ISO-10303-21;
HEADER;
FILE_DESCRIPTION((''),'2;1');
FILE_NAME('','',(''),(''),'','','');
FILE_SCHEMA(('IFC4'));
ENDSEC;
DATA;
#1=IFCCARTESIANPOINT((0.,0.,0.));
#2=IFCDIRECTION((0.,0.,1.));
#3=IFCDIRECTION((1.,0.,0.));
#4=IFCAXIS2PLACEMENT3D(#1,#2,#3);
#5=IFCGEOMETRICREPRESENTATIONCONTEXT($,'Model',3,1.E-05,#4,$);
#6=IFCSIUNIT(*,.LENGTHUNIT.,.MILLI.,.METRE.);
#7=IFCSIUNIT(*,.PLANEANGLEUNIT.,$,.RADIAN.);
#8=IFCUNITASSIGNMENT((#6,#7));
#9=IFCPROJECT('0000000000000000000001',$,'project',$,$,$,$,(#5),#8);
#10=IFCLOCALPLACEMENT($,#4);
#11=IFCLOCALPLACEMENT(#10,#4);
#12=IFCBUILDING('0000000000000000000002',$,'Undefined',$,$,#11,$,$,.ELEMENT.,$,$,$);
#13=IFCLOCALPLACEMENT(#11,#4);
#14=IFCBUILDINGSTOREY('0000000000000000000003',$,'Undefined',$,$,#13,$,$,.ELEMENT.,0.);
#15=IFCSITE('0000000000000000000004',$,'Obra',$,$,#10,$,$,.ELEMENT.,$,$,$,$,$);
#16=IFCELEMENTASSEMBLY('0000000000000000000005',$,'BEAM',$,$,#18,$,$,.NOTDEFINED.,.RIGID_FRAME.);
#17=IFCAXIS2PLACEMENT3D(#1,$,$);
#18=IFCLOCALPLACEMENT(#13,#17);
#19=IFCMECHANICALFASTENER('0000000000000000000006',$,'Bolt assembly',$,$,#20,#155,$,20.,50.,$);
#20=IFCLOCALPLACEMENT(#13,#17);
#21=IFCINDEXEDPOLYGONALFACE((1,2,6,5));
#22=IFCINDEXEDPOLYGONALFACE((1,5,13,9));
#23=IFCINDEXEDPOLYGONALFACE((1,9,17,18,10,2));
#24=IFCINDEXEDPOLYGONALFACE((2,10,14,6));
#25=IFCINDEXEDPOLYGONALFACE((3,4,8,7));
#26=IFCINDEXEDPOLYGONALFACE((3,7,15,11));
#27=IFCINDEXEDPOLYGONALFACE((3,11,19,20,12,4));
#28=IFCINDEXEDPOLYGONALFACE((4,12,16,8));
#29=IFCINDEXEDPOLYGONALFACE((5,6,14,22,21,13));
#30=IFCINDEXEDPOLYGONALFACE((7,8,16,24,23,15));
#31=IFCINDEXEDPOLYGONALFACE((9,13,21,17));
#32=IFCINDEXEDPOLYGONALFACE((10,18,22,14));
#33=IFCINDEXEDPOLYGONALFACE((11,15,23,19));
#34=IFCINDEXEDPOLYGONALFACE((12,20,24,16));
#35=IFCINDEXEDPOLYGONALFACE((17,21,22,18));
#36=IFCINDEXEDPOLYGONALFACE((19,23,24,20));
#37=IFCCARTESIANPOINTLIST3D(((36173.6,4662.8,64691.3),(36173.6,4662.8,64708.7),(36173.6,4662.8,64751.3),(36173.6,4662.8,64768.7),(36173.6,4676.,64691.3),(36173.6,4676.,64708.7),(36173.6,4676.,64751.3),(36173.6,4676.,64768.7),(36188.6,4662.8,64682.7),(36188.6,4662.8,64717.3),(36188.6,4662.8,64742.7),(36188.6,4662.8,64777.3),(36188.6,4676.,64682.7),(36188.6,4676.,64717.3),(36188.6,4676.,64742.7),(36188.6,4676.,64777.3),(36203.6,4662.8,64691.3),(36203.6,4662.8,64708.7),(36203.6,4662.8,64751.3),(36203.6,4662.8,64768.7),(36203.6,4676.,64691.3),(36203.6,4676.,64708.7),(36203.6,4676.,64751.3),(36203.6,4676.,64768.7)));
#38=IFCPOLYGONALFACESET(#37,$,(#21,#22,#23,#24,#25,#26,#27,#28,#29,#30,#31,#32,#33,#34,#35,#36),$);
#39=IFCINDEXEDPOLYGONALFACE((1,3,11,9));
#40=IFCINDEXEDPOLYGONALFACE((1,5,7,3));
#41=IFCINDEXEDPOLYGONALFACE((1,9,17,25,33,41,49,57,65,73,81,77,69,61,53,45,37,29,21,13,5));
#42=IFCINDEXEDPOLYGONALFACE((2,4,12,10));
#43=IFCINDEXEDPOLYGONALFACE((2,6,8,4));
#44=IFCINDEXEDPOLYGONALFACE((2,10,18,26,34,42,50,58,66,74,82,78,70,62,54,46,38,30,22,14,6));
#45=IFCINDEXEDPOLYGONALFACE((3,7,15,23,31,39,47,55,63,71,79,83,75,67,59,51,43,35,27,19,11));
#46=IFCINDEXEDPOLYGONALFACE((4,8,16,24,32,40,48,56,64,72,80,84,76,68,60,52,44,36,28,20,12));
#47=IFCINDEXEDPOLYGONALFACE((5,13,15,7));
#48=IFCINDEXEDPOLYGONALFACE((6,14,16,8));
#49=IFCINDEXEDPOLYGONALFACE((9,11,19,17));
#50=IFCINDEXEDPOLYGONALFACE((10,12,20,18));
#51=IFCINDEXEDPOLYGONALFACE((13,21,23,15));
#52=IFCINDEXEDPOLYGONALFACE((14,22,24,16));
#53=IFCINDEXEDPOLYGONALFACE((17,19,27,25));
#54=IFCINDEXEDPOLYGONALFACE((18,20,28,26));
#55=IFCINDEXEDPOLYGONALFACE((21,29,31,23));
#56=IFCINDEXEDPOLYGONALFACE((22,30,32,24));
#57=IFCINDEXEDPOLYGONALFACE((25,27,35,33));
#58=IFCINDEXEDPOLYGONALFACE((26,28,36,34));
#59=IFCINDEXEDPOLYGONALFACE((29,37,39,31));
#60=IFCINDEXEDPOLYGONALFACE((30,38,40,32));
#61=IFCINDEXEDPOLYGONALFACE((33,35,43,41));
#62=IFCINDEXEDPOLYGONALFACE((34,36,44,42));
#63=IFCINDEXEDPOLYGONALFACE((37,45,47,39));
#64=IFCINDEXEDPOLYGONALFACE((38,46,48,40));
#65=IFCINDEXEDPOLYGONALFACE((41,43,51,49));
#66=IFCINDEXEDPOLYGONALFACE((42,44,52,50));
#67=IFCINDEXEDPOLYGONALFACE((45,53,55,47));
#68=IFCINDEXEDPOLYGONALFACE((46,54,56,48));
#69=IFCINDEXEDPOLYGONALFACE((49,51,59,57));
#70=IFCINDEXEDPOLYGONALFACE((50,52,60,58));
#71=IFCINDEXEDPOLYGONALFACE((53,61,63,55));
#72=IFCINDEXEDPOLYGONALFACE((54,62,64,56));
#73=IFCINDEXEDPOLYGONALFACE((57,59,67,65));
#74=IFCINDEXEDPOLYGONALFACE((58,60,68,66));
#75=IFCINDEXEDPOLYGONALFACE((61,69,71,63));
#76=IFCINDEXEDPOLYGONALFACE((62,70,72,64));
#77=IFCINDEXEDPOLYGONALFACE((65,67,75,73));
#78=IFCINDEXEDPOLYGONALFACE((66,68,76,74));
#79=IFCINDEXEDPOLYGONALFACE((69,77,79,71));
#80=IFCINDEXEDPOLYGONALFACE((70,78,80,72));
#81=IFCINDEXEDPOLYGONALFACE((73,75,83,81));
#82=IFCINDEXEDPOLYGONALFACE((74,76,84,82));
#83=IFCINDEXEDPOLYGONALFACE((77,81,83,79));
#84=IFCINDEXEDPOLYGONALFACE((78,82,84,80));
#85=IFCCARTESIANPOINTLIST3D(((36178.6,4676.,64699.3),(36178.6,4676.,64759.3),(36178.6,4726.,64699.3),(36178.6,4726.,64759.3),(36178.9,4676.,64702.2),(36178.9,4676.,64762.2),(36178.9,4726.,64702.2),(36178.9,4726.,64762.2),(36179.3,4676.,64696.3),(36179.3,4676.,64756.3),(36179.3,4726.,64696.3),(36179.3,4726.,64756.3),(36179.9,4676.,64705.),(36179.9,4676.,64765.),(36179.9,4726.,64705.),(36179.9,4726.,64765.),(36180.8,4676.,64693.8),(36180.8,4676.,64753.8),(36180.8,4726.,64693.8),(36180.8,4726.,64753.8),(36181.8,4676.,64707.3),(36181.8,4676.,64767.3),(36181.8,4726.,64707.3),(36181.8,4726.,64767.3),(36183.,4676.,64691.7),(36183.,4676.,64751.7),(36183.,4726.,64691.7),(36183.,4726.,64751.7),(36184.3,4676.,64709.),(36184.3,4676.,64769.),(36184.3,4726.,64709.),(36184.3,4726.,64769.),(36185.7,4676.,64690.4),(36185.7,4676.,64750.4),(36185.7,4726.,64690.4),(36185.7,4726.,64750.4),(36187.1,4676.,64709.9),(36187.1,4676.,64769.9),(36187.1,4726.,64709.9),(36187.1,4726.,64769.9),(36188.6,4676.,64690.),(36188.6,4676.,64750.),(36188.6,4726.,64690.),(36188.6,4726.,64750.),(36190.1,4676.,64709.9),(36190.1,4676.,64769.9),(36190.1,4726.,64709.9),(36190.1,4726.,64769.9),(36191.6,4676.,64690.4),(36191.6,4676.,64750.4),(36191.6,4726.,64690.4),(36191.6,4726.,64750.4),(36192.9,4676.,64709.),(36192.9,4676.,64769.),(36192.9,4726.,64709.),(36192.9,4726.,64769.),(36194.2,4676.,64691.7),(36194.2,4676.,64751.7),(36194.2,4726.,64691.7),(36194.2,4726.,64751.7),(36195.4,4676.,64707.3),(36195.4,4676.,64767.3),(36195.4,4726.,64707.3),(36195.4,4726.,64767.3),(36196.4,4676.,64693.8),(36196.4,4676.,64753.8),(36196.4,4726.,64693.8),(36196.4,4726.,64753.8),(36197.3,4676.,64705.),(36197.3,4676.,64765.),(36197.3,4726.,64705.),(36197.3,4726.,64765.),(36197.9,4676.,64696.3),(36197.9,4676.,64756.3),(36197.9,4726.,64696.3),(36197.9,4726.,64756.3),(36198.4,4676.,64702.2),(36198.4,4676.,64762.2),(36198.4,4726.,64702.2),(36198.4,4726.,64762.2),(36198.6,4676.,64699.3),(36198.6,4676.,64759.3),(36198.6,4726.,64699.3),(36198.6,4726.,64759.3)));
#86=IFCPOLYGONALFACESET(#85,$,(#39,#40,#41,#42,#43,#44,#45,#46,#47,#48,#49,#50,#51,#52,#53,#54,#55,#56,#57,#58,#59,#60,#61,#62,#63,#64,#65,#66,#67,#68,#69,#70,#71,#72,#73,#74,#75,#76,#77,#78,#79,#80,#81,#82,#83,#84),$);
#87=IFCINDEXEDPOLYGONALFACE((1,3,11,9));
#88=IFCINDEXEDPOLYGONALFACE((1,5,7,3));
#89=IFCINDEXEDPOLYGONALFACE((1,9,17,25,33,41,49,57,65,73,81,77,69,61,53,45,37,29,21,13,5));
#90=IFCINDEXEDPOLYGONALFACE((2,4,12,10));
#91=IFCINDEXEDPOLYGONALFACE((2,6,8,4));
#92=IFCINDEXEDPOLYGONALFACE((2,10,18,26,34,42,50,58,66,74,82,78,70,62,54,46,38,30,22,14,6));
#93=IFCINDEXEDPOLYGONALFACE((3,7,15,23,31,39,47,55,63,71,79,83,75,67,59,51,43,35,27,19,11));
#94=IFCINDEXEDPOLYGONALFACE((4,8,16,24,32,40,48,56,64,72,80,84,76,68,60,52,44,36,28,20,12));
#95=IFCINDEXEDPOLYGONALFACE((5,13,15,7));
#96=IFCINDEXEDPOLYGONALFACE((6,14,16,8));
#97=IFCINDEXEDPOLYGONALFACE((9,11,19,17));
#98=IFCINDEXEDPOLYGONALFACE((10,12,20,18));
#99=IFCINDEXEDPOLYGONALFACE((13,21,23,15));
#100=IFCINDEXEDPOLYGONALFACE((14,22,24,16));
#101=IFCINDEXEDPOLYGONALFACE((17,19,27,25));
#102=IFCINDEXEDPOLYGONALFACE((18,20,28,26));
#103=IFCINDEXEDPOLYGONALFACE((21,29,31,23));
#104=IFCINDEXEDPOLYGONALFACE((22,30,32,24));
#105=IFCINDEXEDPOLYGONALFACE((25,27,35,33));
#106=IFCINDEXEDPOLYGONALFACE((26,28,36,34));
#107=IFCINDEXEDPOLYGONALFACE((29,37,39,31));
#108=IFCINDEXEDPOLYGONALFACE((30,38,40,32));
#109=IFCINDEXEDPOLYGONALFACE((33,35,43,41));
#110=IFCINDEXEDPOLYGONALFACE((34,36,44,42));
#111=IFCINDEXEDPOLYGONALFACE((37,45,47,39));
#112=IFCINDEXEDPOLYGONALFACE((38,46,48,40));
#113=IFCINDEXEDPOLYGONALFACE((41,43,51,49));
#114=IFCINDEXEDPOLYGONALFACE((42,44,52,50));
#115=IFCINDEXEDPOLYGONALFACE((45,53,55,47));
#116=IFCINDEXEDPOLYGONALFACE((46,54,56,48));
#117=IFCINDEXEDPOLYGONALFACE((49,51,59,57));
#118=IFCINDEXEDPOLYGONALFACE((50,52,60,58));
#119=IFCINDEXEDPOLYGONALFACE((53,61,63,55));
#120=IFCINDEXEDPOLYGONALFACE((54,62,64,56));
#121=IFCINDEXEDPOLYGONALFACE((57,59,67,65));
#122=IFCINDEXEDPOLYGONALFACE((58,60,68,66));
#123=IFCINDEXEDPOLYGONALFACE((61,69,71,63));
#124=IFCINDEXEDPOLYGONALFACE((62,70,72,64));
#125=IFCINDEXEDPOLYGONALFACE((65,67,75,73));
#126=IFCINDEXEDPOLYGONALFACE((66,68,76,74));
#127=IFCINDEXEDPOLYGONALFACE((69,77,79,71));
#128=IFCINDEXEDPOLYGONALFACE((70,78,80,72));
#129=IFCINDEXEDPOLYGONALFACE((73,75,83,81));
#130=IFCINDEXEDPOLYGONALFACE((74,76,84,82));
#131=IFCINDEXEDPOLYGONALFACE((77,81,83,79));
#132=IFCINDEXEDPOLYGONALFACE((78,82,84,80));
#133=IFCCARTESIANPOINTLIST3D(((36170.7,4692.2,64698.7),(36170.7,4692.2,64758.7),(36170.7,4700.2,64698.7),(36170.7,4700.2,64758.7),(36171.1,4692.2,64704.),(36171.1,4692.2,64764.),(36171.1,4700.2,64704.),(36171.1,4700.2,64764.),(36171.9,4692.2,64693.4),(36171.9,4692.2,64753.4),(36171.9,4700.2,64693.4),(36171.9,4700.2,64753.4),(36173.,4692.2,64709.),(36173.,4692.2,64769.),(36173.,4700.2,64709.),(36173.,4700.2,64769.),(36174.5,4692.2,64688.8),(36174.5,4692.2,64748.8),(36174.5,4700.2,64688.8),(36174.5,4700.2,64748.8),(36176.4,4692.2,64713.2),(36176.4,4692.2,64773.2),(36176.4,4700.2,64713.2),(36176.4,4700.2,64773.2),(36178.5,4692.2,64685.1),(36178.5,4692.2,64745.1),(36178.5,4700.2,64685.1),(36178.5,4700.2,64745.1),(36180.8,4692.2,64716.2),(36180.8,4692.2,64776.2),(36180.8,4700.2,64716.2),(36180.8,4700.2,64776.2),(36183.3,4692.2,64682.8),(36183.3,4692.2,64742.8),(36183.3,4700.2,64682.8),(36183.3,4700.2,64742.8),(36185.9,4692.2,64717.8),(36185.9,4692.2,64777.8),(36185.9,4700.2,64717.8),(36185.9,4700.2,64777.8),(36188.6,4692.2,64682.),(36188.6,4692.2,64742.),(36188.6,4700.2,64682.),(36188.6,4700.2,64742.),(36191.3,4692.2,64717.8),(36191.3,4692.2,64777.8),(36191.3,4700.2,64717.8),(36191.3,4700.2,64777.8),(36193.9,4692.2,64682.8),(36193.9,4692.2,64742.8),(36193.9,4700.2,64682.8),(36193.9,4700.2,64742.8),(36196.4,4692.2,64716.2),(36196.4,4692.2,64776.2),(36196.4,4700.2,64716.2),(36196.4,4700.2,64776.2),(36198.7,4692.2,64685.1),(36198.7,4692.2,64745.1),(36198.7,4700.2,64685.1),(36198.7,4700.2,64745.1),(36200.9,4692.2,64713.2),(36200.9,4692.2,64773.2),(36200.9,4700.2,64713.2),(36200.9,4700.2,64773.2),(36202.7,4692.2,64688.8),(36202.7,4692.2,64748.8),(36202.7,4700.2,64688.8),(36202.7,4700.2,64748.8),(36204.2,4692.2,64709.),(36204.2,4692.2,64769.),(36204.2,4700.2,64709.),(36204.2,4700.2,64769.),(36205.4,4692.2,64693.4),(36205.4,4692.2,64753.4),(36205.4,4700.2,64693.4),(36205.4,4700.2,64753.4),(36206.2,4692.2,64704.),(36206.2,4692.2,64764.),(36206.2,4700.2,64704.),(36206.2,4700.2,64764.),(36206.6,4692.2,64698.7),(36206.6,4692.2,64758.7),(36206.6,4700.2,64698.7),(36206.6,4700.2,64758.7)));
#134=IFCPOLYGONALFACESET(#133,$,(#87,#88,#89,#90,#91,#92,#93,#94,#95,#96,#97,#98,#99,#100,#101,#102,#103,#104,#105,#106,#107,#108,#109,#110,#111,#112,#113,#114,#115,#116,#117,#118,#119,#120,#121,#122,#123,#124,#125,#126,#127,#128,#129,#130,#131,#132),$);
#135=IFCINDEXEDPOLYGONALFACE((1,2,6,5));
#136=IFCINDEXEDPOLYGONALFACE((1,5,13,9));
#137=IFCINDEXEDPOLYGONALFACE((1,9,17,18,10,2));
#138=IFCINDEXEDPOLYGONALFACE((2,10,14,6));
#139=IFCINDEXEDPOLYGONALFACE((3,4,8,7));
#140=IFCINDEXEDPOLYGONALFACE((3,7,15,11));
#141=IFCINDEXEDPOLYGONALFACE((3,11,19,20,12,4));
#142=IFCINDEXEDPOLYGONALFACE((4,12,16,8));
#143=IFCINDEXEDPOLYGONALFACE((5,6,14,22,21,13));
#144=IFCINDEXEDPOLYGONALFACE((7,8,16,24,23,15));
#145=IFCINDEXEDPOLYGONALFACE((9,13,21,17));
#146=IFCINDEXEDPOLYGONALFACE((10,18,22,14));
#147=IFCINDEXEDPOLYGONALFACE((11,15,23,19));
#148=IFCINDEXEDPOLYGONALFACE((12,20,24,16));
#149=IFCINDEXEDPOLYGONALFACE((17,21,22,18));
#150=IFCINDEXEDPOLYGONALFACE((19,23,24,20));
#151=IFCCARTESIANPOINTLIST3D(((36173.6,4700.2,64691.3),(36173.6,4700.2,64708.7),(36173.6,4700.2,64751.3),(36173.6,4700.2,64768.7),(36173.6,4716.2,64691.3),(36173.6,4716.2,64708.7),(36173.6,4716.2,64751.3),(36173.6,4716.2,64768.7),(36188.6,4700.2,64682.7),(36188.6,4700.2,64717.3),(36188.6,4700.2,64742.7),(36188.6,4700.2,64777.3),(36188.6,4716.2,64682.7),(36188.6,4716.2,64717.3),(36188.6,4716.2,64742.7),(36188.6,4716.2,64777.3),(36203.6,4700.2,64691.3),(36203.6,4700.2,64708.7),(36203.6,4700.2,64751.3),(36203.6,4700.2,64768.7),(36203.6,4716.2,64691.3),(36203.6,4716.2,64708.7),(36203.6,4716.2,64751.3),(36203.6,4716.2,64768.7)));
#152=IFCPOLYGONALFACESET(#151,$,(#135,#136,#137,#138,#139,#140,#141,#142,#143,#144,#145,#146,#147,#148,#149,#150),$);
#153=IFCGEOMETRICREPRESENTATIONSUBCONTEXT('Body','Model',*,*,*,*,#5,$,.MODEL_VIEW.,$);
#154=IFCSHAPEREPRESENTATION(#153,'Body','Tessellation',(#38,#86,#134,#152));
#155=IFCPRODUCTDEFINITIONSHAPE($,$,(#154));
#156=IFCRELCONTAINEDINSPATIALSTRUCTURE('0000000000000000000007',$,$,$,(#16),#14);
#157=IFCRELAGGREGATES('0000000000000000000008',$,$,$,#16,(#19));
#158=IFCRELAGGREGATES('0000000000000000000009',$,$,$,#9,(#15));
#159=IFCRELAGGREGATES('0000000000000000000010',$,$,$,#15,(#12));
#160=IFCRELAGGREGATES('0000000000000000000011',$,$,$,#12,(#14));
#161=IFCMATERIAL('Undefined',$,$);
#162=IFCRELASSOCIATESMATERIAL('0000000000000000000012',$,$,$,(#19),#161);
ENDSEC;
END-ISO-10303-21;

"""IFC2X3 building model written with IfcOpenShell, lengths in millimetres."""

from ifc_helpers import new_model, si_unit, frame, origin_with_axes, origin_2d_with_axis, place, context, subcontext, project, spatial, polyline, circle, outline, extrude, source, transform, mapped, material, element, aggregate, save


model = new_model("IFC2X3")

# Units and contexts
model_context = context("Model", 3, precision=1e-05, world=origin_with_axes())
body_context = subcontext(model_context, "Body", "Model", "MODEL_VIEW")
ifc_project = project(units=[si_unit("LENGTHUNIT", "METRE", prefix="MILLI"), si_unit("PLANEANGLEUNIT", "RADIAN")], contexts=[model_context])

# Site, building, storey
site_placement = place(None, origin_with_axes())
site = spatial("IfcSite", under=ifc_project, at=site_placement, Name="Obra", CompositionType="ELEMENT")
building_placement = place(site_placement, origin_with_axes())
building = spatial("IfcBuilding", under=site, at=building_placement, Name="Undefined", CompositionType="ELEMENT")
storey_placement = place(building_placement, origin_with_axes())
storey = spatial("IfcBuildingStorey", under=building, at=storey_placement, Name="Undefined", CompositionType="ELEMENT", Elevation=0.0)

# Shared definitions
ifc_material = material(Name="Undefined")

# Element assembly, mechanical fastener
shared_shape_1 = source(origin_with_axes(), body_context, "Body", "SweptSolid", [
    extrude(outline(polyline([(17.3, 0.0), (8.7, 15.0), (-8.7, 15.0), (-17.3, 0.0), (-8.7, -15.0), (8.7, -15.0), (17.3, 0.0)])), frame((0.0, -26.3, 0.0), z_axis=(0.0, 1.0, 0.0), x_axis=(1.0, 0.0, 0.0)), (0.0, 0.0, 1.0), 13.2),
    extrude(circle(Radius=10.0, at=origin_2d_with_axis()), frame((0.0, -13.1, 0.0), z_axis=(0.0, 1.0, 0.0), x_axis=(1.0, 0.0, 0.0)), (0.0, 0.0, 1.0), 50.0),
    extrude(circle(Radius=18.0, at=origin_2d_with_axis()), frame((0.0, 3.1, 0.0), z_axis=(0.0, 1.0, 0.0), x_axis=(1.0, 0.0, 0.0)), (0.0, 0.0, 1.0), 8.0),
    extrude(outline(polyline([(17.3, 0.0), (8.7, 15.0), (-8.7, 15.0), (-17.3, 0.0), (-8.7, -15.0), (8.7, -15.0), (17.3, 0.0)])), frame((0.0, 11.1, 0.0), z_axis=(0.0, 1.0, 0.0), x_axis=(1.0, 0.0, 0.0)), (0.0, 0.0, 1.0), 16.0),
])
assembly_1_placement = place(storey_placement, origin_with_axes())
assembly_1 = element("IfcElementAssembly", 1, at=assembly_1_placement, inside=storey, Name="BEAM", AssemblyPlace="NOTDEFINED", PredefinedType="RIGID_FRAME")
mechanical_fastener_1_placement = place(assembly_1_placement, frame((36148.6, 4689.1, 64850.0), z_axis=(1.0, 0.0, 0.0), x_axis=(0.0, 0.0, -1.0)))
mechanical_fastener_1 = element("IfcMechanicalFastener", 2, at=mechanical_fastener_1_placement, material=ifc_material, Name="Bolt assembly", NominalDiameter=20.0, NominalLength=50.0, context=body_context, shape_type="MappedRepresentation", body=[
    mapped(shared_shape_1, transform((90.0, 0.0, 40.0))),
    mapped(shared_shape_1, transform((150.0, 0.0, 40.0))),
])
aggregate(assembly_1, [mechanical_fastener_1])

save(model, "model.ifc")
